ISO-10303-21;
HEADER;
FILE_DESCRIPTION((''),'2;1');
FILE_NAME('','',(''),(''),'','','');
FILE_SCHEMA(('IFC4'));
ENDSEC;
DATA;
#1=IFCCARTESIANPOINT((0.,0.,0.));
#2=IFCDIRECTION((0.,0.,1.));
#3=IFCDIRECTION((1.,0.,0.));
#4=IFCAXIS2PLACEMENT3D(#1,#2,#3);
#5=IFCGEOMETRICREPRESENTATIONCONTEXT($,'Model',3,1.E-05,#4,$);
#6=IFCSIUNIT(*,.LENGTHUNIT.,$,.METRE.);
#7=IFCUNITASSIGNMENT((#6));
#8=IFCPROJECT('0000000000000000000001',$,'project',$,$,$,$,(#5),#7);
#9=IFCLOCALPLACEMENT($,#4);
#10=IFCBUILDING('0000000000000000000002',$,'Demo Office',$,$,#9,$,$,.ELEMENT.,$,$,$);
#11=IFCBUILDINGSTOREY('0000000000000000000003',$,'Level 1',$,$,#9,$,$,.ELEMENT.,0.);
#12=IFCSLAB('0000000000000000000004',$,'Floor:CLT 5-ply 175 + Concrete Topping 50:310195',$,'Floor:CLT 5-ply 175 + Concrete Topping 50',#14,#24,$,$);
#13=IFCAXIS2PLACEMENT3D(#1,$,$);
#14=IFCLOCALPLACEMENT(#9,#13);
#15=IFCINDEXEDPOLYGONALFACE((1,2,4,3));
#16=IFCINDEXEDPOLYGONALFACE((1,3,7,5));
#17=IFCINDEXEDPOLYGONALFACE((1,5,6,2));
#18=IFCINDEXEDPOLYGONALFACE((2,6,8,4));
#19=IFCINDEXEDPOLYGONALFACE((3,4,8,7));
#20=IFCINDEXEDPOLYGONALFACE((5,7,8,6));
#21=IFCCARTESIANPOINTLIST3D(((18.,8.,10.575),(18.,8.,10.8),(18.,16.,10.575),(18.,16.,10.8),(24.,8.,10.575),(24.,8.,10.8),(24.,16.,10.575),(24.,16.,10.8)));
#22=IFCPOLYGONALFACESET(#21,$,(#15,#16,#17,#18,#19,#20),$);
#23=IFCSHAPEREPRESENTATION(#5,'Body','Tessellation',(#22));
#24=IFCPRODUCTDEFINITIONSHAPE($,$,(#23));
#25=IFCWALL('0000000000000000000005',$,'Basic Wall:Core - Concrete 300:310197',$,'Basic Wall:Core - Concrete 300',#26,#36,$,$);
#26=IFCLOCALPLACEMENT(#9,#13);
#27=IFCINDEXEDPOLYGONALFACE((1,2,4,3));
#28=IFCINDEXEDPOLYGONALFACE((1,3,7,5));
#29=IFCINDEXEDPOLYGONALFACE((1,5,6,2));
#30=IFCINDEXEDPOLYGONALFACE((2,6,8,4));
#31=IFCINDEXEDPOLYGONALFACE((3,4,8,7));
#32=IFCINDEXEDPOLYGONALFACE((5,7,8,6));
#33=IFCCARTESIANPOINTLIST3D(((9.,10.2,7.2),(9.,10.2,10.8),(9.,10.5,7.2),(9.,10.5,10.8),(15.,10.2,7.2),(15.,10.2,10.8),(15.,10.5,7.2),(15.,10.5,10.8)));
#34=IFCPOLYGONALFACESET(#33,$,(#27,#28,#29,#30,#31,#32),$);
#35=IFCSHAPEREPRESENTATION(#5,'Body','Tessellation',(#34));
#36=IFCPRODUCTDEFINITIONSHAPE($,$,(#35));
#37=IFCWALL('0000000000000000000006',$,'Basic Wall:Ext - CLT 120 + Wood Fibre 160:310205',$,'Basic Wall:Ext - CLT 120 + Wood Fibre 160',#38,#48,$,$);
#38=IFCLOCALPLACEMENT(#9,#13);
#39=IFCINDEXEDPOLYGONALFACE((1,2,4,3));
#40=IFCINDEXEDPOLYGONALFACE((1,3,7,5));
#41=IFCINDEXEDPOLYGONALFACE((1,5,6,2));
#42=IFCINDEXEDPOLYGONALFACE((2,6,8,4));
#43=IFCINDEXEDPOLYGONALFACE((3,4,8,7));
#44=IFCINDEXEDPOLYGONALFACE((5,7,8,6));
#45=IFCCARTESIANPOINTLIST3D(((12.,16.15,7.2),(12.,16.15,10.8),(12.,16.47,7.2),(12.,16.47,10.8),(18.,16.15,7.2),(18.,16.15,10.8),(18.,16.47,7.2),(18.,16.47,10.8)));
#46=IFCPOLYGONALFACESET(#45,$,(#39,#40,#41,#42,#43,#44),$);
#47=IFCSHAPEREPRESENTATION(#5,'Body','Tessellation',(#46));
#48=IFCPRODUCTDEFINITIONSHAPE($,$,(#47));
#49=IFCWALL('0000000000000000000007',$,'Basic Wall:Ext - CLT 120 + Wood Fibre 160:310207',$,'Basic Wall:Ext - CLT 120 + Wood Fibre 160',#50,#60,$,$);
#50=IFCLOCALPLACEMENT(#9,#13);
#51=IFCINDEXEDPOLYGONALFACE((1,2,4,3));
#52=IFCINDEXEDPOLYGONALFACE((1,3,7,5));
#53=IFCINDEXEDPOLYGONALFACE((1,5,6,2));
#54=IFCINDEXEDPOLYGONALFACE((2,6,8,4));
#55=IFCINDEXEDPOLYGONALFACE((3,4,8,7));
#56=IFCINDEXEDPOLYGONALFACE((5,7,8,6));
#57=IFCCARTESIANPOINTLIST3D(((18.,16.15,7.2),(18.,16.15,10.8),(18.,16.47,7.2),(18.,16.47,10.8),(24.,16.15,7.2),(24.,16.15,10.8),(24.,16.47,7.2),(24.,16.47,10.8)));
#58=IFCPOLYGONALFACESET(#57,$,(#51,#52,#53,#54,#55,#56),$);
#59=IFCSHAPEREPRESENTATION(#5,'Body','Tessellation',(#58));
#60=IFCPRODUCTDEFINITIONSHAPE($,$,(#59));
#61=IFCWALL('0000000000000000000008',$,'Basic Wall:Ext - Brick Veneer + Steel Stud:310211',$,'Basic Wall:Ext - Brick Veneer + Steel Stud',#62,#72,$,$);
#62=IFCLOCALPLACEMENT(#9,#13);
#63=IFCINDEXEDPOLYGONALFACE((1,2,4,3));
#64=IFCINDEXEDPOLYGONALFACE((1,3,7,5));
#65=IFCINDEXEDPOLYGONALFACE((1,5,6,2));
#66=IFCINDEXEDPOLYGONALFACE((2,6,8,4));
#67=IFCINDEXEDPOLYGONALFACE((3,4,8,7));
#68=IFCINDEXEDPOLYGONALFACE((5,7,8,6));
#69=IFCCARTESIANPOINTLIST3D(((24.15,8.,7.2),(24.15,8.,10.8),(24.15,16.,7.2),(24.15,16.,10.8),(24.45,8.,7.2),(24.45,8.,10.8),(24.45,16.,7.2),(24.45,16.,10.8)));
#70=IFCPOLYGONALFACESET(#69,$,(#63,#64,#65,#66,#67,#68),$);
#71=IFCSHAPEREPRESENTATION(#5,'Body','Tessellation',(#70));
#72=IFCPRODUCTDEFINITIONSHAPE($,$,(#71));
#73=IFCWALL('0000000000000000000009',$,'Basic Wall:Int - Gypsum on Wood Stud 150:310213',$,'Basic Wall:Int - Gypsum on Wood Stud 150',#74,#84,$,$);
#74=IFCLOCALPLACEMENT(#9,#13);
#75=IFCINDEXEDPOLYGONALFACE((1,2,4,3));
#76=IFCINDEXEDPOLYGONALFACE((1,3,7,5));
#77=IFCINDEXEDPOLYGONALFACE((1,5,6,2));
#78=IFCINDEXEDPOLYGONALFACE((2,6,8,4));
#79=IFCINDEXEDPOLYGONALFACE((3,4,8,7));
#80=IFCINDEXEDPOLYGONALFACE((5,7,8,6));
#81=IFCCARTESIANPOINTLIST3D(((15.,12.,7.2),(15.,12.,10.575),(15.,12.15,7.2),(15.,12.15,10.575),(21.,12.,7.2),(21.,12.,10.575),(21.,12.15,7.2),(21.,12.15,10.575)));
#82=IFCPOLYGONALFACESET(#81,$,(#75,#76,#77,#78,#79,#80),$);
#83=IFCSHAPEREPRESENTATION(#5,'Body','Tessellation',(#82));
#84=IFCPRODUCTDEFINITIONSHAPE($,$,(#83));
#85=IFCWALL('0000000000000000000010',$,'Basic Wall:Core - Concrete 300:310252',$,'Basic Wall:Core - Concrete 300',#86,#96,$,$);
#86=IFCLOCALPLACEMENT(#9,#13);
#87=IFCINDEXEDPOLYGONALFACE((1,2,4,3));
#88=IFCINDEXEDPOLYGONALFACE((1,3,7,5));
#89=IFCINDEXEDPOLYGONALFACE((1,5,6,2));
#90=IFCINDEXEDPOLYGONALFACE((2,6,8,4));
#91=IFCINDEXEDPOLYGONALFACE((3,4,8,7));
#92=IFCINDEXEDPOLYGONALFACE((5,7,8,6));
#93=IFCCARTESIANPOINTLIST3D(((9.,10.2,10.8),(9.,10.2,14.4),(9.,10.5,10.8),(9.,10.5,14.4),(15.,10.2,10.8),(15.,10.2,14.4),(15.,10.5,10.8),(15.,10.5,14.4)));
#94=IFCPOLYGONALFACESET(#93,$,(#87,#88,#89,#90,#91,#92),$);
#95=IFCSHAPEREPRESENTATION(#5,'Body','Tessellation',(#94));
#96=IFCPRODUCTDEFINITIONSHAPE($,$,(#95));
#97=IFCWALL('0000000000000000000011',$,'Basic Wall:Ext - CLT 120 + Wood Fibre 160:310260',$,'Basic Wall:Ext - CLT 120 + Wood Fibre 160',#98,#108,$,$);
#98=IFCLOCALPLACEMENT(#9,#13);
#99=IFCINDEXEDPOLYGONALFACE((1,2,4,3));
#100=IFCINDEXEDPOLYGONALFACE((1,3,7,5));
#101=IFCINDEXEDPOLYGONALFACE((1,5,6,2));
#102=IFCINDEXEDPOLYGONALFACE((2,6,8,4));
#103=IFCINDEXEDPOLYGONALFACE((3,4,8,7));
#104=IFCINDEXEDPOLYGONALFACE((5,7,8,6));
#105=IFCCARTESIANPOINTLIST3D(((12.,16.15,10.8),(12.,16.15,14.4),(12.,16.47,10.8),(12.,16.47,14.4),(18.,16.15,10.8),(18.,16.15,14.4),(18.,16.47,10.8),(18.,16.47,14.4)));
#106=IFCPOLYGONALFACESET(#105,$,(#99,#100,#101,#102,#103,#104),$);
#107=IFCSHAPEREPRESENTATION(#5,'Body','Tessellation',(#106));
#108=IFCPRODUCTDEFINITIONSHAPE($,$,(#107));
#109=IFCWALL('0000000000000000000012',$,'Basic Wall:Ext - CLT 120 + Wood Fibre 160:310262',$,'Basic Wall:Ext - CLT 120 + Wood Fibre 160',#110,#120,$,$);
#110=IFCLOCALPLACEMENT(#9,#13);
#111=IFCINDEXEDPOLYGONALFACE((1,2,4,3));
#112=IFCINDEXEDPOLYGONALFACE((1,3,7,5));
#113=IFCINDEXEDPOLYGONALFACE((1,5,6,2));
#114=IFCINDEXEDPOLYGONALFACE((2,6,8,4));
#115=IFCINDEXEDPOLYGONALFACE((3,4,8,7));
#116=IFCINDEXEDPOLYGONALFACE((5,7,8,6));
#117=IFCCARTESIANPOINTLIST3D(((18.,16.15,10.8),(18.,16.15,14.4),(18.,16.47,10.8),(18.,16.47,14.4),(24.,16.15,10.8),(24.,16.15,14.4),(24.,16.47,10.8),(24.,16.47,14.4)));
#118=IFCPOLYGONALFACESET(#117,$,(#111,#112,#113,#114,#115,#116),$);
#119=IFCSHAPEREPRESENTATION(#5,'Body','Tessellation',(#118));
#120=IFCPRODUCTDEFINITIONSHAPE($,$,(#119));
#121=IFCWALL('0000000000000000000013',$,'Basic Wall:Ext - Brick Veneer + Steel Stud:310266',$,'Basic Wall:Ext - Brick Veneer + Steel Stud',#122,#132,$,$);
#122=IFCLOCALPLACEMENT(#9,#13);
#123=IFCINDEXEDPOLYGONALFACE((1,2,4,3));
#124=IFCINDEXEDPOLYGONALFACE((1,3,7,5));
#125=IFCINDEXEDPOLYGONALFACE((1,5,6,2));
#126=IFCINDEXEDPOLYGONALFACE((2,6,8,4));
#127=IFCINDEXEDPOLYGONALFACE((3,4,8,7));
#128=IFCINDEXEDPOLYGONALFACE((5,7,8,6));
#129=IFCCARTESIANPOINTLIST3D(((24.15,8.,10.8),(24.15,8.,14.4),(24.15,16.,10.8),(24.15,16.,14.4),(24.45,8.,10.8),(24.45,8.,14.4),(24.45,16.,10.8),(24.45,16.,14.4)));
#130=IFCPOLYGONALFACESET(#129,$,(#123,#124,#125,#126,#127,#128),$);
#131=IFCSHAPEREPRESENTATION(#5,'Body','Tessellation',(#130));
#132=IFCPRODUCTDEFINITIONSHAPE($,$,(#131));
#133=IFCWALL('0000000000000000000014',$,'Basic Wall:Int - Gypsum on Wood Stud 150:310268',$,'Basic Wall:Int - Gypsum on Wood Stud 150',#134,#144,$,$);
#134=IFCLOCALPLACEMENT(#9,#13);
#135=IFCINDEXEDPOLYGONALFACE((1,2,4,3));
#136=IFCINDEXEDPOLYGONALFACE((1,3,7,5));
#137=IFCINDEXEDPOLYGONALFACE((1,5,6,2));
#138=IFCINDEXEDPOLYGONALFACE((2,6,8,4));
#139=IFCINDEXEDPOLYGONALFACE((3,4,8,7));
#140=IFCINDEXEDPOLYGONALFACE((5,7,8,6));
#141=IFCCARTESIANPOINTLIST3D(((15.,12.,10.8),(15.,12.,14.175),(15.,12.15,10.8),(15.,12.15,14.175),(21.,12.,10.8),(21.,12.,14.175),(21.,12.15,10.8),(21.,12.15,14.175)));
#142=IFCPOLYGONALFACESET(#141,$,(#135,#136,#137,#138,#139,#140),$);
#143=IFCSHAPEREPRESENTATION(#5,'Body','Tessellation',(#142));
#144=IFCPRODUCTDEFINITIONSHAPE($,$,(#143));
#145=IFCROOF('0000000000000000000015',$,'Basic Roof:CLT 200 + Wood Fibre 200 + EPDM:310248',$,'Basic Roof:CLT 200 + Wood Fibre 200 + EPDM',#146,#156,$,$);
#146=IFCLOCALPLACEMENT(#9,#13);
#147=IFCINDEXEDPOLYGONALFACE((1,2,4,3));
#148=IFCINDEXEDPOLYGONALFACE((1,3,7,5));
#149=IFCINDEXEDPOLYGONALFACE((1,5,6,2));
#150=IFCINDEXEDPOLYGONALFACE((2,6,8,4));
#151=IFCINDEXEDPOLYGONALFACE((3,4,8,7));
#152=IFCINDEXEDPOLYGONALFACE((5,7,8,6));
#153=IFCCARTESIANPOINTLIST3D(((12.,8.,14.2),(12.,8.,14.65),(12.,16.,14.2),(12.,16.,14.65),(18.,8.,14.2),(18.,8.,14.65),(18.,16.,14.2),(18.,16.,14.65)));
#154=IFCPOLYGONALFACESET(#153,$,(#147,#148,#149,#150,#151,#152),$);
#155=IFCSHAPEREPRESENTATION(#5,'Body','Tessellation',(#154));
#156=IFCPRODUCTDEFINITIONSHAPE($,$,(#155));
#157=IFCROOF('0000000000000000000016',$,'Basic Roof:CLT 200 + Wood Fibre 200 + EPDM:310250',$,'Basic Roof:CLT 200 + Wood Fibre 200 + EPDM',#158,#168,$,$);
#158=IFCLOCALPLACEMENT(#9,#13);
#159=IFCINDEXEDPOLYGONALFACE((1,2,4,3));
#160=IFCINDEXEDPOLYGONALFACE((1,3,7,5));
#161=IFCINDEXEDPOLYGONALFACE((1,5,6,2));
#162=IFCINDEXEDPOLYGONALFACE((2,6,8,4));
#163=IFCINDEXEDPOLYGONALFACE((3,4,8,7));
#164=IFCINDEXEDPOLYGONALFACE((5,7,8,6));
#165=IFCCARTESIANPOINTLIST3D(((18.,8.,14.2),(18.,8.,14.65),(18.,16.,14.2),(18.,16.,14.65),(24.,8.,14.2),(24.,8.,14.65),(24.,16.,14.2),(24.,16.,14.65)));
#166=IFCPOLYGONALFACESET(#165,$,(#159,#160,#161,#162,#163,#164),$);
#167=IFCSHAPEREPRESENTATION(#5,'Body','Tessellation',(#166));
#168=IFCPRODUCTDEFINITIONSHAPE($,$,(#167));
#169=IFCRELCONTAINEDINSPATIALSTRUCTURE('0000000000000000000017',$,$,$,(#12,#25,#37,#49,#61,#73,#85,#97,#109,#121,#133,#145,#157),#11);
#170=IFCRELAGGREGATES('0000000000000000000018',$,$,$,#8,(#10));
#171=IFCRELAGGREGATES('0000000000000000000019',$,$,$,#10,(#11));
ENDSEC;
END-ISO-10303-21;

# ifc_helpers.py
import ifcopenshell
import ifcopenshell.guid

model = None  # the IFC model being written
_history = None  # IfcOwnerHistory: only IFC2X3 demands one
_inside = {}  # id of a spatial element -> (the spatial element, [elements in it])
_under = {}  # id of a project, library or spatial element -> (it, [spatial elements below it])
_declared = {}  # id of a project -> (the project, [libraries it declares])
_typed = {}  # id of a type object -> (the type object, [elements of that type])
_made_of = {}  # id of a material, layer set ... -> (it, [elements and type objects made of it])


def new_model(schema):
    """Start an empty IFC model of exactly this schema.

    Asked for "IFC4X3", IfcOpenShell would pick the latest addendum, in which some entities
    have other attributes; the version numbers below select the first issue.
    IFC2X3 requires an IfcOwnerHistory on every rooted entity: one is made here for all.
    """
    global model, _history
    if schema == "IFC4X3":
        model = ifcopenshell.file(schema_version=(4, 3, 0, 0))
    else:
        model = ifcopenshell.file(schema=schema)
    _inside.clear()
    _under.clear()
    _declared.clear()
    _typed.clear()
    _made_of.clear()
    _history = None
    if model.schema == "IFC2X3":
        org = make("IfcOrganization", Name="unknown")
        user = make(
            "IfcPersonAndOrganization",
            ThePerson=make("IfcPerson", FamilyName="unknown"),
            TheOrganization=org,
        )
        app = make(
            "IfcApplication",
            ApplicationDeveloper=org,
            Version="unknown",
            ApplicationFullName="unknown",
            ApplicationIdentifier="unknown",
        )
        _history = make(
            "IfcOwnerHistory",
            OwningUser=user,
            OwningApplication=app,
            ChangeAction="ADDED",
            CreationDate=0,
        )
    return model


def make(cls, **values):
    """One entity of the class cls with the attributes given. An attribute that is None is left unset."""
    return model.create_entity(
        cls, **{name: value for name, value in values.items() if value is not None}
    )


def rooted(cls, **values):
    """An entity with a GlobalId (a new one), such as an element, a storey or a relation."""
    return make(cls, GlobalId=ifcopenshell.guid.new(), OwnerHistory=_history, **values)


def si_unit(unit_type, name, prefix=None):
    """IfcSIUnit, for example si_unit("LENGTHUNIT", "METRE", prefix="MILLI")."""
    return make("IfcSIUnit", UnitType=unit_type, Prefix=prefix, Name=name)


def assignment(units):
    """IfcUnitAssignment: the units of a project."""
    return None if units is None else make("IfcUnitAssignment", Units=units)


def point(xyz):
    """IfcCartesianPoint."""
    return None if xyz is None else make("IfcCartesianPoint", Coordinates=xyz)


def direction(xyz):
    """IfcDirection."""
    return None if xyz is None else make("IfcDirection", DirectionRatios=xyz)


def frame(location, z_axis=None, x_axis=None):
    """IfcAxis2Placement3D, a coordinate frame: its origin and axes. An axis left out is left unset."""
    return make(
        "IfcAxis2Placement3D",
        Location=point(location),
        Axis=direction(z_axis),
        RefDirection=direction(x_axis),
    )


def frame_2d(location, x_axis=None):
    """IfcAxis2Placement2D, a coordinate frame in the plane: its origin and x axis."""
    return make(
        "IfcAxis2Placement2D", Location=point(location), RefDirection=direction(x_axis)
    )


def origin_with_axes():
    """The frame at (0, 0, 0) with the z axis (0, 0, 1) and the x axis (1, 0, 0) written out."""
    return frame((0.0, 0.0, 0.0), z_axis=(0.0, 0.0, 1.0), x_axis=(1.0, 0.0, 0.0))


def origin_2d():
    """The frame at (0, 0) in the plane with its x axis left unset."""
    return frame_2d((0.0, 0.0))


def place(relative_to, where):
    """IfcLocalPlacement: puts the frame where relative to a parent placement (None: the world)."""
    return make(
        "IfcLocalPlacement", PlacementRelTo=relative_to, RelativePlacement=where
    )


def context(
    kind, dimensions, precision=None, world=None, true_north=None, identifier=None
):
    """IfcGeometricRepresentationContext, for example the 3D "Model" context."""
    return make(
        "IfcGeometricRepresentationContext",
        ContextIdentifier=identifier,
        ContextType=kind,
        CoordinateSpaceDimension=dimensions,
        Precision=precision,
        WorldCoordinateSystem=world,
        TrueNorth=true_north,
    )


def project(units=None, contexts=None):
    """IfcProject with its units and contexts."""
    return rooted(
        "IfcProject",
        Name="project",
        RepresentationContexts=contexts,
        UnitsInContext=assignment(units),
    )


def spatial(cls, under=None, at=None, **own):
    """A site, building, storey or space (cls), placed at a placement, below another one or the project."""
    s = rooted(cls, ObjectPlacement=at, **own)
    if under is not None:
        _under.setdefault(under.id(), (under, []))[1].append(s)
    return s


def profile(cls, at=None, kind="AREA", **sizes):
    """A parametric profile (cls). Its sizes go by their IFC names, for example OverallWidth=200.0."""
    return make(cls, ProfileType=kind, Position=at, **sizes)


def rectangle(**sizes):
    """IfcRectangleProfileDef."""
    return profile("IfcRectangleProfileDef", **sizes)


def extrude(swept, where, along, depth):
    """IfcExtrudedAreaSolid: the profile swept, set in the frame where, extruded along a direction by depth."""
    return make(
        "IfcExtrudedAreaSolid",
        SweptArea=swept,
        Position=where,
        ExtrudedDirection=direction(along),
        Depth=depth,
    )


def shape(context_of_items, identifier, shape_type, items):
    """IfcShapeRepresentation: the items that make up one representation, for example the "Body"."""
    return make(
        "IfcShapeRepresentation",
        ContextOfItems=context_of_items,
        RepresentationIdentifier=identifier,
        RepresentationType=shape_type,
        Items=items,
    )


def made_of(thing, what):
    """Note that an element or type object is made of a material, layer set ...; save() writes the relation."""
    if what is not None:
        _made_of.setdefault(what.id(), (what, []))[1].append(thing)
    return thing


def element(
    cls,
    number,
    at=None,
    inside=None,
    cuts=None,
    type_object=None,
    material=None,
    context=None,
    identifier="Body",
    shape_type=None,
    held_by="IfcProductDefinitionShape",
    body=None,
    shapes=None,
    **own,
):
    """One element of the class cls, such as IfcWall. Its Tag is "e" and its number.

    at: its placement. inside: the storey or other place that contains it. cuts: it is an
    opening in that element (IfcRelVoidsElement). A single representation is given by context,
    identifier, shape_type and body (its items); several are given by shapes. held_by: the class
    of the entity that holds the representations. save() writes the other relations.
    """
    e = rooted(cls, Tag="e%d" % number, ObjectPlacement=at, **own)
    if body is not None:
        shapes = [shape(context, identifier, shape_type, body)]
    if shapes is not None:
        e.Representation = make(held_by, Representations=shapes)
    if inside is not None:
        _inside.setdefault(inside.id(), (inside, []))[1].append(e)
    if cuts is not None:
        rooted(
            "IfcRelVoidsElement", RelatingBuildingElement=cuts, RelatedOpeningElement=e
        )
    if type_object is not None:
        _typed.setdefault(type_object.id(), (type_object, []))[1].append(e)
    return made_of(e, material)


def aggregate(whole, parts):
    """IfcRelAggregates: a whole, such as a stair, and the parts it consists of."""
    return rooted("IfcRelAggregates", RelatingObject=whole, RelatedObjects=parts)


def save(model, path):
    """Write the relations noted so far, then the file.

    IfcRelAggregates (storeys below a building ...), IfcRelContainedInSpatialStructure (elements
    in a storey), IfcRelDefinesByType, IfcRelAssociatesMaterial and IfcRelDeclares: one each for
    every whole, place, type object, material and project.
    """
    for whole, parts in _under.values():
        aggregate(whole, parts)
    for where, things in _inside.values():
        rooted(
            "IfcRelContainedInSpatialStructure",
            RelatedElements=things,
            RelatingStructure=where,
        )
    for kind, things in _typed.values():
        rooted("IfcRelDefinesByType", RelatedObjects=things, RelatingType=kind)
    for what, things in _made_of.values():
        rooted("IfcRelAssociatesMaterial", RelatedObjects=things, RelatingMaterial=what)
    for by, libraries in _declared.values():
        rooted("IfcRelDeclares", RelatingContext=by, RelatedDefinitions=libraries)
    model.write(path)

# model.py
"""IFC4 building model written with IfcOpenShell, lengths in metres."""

from ifc_helpers import new_model, si_unit, frame, origin_with_axes, origin_2d, place, context, project, spatial, rectangle, extrude, element, save


model = new_model("IFC4")

# Units and contexts
model_context = context("Model", 3, precision=1e-05, world=origin_with_axes())
ifc_project = project(units=[si_unit("LENGTHUNIT", "METRE")], contexts=[model_context])

# Building, storey
placement = place(None, origin_with_axes())
building = spatial("IfcBuilding", under=ifc_project, at=placement, Name="Demo Office", CompositionType="ELEMENT")
storey = spatial("IfcBuildingStorey", under=building, at=placement, Name="Level 1", CompositionType="ELEMENT", Elevation=0.0)

# Slab
for number, where, name in (
    (1, (21.0, 12.0, 10.575), "Floor:CLT 5-ply 175 + Concrete Topping 50:310195"),
):
    element("IfcSlab", number, at=place(placement, frame(where)), inside=storey, Name=name, ObjectType="Floor:CLT 5-ply 175 + Concrete Topping 50", context=model_context, shape_type="SweptSolid", body=[
        extrude(rectangle(XDim=6.0, YDim=8.0, at=origin_2d()), origin_with_axes(), (0.0, 0.0, 1.0), 0.225),
    ])

# Walls
wall_1_placement = place(placement, frame((12.0, 10.35, 7.2)))
element("IfcWall", 2, at=wall_1_placement, inside=storey, Name="Basic Wall:Core - Concrete 300:310197", ObjectType="Basic Wall:Core - Concrete 300", context=model_context, shape_type="SweptSolid", body=[
    extrude(rectangle(XDim=6.0, YDim=0.3, at=origin_2d()), origin_with_axes(), (0.0, 0.0, 1.0), 3.6),
])
for number, where, name in (
    (3, (15.0, 16.31, 7.2), "Basic Wall:Ext - CLT 120 + Wood Fibre 160:310205"),
    (4, (21.0, 16.31, 7.2), "Basic Wall:Ext - CLT 120 + Wood Fibre 160:310207"),
):
    element("IfcWall", number, at=place(placement, frame(where)), inside=storey, Name=name, ObjectType="Basic Wall:Ext - CLT 120 + Wood Fibre 160", context=model_context, shape_type="SweptSolid", body=[
        extrude(rectangle(XDim=6.0, YDim=0.32, at=origin_2d()), origin_with_axes(), (0.0, 0.0, 1.0), 3.6),
    ])
wall_2_placement = place(placement, frame((24.3, 12.0, 7.2)))
element("IfcWall", 5, at=wall_2_placement, inside=storey, Name="Basic Wall:Ext - Brick Veneer + Steel Stud:310211", ObjectType="Basic Wall:Ext - Brick Veneer + Steel Stud", context=model_context, shape_type="SweptSolid", body=[
    extrude(rectangle(XDim=0.3, YDim=8.0, at=origin_2d()), origin_with_axes(), (0.0, 0.0, 1.0), 3.6),
])
wall_3_placement = place(placement, frame((18.0, 12.075, 7.2)))
element("IfcWall", 6, at=wall_3_placement, inside=storey, Name="Basic Wall:Int - Gypsum on Wood Stud 150:310213", ObjectType="Basic Wall:Int - Gypsum on Wood Stud 150", context=model_context, shape_type="SweptSolid", body=[
    extrude(rectangle(XDim=6.0, YDim=0.15, at=origin_2d()), origin_with_axes(), (0.0, 0.0, 1.0), 3.375),
])
wall_4_placement = place(placement, frame((12.0, 10.35, 10.8)))
element("IfcWall", 7, at=wall_4_placement, inside=storey, Name="Basic Wall:Core - Concrete 300:310252", ObjectType="Basic Wall:Core - Concrete 300", context=model_context, shape_type="SweptSolid", body=[
    extrude(rectangle(XDim=6.0, YDim=0.3, at=origin_2d()), origin_with_axes(), (0.0, 0.0, 1.0), 3.6),
])
for number, where, name in (
    (8, (15.0, 16.31, 10.8), "Basic Wall:Ext - CLT 120 + Wood Fibre 160:310260"),
    (9, (21.0, 16.31, 10.8), "Basic Wall:Ext - CLT 120 + Wood Fibre 160:310262"),
):
    element("IfcWall", number, at=place(placement, frame(where)), inside=storey, Name=name, ObjectType="Basic Wall:Ext - CLT 120 + Wood Fibre 160", context=model_context, shape_type="SweptSolid", body=[
        extrude(rectangle(XDim=6.0, YDim=0.32, at=origin_2d()), origin_with_axes(), (0.0, 0.0, 1.0), 3.6),
    ])
wall_5_placement = place(placement, frame((24.3, 12.0, 10.8)))
element("IfcWall", 10, at=wall_5_placement, inside=storey, Name="Basic Wall:Ext - Brick Veneer + Steel Stud:310266", ObjectType="Basic Wall:Ext - Brick Veneer + Steel Stud", context=model_context, shape_type="SweptSolid", body=[
    extrude(rectangle(XDim=0.3, YDim=8.0, at=origin_2d()), origin_with_axes(), (0.0, 0.0, 1.0), 3.6),
])
wall_6_placement = place(placement, frame((18.0, 12.075, 10.8)))
element("IfcWall", 11, at=wall_6_placement, inside=storey, Name="Basic Wall:Int - Gypsum on Wood Stud 150:310268", ObjectType="Basic Wall:Int - Gypsum on Wood Stud 150", context=model_context, shape_type="SweptSolid", body=[
    extrude(rectangle(XDim=6.0, YDim=0.15, at=origin_2d()), origin_with_axes(), (0.0, 0.0, 1.0), 3.375),
])

# Roofs
for number, where, name in (
    (12, (15.0, 12.0, 14.2), "Basic Roof:CLT 200 + Wood Fibre 200 + EPDM:310248"),
    (13, (21.0, 12.0, 14.2), "Basic Roof:CLT 200 + Wood Fibre 200 + EPDM:310250"),
):
    element("IfcRoof", number, at=place(placement, frame(where)), inside=storey, Name=name, ObjectType="Basic Roof:CLT 200 + Wood Fibre 200 + EPDM", context=model_context, shape_type="SweptSolid", body=[
        extrude(rectangle(XDim=6.0, YDim=8.0, at=origin_2d()), origin_with_axes(), (0.0, 0.0, 1.0), 0.45),
    ])

save(model, "model.ifc")
